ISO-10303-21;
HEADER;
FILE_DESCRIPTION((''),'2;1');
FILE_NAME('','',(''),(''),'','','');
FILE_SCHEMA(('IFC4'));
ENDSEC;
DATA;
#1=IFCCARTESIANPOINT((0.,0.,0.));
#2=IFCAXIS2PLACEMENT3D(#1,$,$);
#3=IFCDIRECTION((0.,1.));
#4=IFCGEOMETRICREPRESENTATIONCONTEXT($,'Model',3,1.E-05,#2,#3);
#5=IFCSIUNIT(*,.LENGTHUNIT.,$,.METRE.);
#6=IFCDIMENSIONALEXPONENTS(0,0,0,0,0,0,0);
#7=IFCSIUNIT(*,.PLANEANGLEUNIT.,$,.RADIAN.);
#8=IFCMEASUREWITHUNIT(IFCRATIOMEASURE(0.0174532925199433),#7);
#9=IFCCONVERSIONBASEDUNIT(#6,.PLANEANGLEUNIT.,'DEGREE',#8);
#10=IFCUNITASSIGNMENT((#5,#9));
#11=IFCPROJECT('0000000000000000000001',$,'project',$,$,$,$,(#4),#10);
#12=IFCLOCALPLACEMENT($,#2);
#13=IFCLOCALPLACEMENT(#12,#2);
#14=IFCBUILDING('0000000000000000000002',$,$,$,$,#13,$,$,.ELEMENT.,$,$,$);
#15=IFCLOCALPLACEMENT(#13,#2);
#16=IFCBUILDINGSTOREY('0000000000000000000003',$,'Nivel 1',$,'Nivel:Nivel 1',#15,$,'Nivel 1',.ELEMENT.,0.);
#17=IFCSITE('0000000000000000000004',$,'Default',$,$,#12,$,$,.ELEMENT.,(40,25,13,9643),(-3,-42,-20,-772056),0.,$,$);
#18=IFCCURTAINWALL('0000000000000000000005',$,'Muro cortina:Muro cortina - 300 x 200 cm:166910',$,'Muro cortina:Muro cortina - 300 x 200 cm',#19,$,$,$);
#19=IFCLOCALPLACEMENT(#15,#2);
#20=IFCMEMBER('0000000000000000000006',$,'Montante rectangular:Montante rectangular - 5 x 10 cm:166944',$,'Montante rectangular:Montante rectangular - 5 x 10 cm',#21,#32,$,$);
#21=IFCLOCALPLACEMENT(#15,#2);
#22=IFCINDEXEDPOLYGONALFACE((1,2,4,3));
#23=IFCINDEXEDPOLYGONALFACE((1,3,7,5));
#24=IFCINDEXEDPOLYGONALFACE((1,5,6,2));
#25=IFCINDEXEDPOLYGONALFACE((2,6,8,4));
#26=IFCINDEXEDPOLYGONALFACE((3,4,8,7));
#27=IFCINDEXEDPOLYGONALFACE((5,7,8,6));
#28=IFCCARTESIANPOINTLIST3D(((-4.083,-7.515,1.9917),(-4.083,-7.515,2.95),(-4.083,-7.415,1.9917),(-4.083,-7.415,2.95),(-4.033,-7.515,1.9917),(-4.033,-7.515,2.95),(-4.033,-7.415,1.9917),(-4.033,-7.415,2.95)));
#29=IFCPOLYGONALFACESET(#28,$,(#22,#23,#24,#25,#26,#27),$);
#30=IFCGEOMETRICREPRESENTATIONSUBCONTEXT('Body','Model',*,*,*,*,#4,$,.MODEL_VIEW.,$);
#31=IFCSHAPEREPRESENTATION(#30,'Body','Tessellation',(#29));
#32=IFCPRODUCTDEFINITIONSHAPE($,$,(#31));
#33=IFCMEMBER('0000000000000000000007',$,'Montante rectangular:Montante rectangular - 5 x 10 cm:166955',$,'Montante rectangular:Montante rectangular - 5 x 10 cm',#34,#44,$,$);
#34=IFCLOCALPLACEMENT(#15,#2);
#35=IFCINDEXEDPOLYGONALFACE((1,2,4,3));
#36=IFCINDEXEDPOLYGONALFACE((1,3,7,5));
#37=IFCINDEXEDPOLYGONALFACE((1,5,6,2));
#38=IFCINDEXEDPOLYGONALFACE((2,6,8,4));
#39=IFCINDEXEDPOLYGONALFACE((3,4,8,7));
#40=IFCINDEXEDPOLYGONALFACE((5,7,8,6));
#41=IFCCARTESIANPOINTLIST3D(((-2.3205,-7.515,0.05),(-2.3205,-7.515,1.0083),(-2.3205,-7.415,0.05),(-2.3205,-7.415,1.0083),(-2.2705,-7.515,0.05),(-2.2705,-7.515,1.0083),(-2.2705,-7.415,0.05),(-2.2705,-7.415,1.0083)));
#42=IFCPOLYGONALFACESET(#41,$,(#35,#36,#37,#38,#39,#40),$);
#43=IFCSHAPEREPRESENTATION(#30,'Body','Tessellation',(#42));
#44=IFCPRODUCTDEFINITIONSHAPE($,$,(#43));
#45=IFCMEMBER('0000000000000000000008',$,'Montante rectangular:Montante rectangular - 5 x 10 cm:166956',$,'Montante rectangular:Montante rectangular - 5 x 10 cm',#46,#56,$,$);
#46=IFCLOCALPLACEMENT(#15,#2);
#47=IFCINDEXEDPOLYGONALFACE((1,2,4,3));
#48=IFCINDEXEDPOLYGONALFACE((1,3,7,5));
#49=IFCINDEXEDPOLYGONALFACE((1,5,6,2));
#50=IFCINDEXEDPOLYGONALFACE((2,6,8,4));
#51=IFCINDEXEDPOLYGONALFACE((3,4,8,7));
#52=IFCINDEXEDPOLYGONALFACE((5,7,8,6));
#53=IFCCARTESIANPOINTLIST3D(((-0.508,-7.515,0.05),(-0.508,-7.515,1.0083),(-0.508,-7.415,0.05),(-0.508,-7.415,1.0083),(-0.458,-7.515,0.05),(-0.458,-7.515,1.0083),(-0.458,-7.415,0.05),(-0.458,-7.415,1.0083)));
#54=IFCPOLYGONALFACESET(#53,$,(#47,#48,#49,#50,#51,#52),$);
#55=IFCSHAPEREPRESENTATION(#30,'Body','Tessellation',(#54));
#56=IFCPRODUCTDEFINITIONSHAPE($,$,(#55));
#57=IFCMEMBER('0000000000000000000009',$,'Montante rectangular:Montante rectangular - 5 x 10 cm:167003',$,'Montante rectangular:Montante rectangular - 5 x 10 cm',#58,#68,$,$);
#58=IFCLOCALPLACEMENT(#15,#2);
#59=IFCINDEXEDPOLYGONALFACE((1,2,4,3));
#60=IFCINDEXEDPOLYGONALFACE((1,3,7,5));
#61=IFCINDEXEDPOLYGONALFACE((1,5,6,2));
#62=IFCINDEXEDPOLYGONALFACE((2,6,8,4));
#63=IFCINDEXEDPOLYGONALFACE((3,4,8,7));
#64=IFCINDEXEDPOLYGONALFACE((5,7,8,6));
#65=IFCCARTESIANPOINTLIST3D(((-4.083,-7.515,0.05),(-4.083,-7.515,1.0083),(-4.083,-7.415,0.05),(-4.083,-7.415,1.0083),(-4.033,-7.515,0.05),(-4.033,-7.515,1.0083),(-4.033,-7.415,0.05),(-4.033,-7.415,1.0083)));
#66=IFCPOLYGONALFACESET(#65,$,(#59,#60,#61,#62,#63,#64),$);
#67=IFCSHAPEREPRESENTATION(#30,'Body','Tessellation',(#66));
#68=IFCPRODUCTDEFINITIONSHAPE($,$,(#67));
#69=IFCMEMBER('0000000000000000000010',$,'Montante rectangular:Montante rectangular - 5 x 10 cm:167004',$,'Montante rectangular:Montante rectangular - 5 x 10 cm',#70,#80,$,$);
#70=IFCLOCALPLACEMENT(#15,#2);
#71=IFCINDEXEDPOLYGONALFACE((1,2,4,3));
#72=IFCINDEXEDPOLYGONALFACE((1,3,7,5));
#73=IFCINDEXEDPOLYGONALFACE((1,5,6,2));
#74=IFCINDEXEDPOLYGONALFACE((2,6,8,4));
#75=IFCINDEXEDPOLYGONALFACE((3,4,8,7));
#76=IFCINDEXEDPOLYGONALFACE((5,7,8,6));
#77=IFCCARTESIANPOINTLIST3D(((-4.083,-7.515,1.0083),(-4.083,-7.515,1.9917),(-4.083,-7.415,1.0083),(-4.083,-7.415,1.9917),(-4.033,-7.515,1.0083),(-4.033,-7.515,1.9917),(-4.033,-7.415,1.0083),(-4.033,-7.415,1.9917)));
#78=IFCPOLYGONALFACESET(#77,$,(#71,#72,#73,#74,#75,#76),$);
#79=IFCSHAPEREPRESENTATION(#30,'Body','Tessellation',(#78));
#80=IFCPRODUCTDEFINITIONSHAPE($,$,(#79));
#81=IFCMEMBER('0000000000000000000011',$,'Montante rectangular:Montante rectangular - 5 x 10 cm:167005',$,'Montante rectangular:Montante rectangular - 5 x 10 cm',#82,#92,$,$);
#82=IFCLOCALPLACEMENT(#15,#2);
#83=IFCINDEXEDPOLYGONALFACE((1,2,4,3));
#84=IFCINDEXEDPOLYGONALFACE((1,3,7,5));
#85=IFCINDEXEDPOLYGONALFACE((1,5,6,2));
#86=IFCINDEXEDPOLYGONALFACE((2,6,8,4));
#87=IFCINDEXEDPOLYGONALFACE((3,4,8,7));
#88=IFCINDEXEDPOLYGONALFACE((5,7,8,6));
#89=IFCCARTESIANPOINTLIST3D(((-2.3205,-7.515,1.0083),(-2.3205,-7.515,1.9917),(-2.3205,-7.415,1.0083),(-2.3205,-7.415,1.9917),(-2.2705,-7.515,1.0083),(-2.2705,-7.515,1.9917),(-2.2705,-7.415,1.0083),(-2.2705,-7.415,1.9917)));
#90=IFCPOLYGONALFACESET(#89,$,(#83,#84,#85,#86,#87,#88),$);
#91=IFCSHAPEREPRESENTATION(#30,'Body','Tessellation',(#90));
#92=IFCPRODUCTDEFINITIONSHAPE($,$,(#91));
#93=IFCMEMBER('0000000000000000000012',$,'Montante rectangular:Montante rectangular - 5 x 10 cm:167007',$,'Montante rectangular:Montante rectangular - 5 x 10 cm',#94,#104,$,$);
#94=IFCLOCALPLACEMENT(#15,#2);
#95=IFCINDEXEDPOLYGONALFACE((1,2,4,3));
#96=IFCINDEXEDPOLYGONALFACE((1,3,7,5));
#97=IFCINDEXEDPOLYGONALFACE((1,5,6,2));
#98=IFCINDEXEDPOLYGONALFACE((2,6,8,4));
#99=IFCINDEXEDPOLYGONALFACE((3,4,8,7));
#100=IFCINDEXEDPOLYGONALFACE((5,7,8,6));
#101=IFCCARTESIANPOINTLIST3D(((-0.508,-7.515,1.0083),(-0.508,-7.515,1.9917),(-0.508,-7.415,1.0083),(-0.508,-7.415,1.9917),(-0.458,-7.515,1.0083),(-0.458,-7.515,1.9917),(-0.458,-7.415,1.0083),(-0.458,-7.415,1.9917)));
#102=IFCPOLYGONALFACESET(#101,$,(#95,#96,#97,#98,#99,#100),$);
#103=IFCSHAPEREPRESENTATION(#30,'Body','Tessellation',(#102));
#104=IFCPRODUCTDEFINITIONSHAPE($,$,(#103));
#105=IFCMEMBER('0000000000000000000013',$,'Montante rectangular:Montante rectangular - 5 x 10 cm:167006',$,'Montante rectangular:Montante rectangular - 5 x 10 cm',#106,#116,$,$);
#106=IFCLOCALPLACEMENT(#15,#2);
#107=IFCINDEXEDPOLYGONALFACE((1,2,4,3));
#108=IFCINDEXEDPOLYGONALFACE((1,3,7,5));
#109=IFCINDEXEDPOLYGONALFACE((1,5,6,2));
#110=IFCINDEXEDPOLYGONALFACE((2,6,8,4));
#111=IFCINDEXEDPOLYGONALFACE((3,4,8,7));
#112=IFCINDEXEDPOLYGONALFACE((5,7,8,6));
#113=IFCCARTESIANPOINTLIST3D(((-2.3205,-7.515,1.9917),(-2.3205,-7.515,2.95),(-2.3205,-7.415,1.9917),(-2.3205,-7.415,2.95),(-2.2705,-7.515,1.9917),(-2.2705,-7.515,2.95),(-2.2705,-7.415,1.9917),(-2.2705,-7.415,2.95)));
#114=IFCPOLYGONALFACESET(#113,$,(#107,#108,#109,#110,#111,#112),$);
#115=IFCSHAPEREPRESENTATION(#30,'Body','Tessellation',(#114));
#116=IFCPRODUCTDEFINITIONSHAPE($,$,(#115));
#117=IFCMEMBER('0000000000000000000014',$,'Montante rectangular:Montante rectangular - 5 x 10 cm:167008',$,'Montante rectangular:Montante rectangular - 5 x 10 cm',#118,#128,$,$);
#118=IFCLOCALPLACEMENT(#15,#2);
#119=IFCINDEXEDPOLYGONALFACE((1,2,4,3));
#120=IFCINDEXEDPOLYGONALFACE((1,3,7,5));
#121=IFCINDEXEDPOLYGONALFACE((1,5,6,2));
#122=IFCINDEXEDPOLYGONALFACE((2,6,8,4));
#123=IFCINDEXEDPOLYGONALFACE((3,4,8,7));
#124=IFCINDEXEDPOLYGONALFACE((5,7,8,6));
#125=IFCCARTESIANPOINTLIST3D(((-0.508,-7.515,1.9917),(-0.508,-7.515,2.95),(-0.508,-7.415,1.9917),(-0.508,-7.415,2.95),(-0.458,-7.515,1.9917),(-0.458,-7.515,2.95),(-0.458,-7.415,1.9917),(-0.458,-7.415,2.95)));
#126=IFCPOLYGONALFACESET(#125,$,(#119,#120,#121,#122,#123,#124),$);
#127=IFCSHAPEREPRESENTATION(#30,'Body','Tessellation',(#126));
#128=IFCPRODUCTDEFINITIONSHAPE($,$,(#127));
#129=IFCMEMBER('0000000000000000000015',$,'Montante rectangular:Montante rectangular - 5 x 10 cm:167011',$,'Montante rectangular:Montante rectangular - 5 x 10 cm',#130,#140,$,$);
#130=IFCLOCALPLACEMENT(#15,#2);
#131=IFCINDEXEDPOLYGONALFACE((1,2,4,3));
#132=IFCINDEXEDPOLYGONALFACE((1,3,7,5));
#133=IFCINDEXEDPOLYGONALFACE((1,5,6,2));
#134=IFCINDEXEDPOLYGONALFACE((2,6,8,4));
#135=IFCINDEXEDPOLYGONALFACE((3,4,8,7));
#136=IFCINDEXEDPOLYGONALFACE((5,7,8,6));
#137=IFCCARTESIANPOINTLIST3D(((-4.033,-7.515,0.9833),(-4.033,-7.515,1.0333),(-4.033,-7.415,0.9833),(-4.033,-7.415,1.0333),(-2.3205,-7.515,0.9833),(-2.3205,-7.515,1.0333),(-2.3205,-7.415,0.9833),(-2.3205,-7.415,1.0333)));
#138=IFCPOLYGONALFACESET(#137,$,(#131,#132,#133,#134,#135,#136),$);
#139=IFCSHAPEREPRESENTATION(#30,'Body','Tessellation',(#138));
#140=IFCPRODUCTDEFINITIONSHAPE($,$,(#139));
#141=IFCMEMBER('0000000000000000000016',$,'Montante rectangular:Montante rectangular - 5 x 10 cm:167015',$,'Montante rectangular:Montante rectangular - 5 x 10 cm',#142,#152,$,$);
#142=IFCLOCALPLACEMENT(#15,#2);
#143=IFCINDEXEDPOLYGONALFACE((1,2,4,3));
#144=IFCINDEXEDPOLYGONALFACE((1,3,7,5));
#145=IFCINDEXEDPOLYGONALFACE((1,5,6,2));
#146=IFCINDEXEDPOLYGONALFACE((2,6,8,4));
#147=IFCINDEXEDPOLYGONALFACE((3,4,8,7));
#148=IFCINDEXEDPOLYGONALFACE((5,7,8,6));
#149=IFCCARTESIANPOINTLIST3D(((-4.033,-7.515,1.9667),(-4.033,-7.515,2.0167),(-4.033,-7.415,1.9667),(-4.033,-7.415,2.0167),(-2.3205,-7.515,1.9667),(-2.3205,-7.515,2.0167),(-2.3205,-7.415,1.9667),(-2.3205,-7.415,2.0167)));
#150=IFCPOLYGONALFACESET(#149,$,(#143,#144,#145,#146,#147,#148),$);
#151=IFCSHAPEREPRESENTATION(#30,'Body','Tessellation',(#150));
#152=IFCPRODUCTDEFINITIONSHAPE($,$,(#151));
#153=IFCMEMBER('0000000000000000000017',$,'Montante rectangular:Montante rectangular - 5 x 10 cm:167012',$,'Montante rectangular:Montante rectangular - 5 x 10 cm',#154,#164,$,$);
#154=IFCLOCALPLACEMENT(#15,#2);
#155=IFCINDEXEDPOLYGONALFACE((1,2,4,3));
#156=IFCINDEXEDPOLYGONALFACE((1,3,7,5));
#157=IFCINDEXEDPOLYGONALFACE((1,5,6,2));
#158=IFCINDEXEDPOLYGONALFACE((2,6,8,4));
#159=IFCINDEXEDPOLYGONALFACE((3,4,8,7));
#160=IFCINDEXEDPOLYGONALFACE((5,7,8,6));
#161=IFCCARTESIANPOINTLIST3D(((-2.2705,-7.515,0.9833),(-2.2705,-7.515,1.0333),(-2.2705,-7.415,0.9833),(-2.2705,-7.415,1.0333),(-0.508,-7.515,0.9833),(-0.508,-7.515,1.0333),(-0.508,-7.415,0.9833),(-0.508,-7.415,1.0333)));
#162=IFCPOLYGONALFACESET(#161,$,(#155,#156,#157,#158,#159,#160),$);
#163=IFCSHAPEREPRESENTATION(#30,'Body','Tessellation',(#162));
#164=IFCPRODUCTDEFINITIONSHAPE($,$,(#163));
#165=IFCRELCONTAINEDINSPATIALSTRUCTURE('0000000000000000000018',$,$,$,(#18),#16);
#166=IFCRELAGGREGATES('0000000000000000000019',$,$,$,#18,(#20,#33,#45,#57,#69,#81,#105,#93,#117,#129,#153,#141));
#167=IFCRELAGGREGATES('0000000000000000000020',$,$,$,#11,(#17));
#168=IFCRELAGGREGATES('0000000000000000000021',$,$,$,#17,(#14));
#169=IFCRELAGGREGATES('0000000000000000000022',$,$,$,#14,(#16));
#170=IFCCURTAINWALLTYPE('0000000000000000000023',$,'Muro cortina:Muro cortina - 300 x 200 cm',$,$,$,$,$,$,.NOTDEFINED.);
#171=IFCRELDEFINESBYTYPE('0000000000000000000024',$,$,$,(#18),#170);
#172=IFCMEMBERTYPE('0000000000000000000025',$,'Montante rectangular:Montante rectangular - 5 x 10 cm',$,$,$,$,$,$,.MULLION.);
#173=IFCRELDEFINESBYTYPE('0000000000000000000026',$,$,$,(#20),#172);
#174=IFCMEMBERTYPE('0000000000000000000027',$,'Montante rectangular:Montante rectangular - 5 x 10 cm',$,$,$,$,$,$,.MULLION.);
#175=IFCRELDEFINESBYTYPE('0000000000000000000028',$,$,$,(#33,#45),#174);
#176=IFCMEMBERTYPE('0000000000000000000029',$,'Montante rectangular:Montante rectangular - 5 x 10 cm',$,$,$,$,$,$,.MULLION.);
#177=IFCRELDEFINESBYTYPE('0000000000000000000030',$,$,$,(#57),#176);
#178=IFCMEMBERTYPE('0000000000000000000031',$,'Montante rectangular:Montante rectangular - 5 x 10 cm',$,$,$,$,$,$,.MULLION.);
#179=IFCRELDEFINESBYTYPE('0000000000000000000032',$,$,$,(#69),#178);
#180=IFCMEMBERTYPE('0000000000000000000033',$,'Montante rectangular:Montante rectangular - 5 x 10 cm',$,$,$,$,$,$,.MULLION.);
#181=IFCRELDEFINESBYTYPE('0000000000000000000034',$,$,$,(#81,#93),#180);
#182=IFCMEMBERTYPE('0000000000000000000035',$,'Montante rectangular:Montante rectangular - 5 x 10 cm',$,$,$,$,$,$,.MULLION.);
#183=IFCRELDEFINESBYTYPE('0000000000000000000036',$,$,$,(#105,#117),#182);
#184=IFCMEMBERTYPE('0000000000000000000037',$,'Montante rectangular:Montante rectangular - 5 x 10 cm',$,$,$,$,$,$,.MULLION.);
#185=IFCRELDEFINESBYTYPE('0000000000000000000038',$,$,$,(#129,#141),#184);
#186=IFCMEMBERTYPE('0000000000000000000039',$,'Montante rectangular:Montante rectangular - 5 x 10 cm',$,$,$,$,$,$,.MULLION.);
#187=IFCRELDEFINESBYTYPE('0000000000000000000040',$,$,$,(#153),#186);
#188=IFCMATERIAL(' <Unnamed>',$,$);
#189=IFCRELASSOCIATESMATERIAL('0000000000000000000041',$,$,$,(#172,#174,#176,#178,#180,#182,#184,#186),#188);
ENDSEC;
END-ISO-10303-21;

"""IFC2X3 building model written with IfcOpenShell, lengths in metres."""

from ifc_helpers import new_model, entity, si_unit, converted_unit, direction, frame, origin, origin_2d_with_axis, place, context, subcontext, project, spatial, rectangle, extrude, source, transform, mapped, material, type_object, type_shapes, element, aggregate, save


model = new_model("IFC2X3")

# Units and contexts
model_context = context("Model", 3, precision=1e-05, world=origin(), true_north=direction((0.0, 1.0)))
body_context = subcontext(model_context, "Body", "Model", "MODEL_VIEW")
ifc_project = project(units=[si_unit("LENGTHUNIT", "METRE"), converted_unit("PLANEANGLEUNIT", "DEGREE", entity("IfcRatioMeasure", 0.0174532925199433), si_unit("PLANEANGLEUNIT", "RADIAN"), dimensions=[0, 0, 0, 0, 0, 0, 0])], contexts=[model_context])

# Site, building, storey
site_placement = place(None, origin())
site = spatial("IfcSite", under=ifc_project, at=site_placement, Name="Default", CompositionType="ELEMENT", RefLatitude=(40, 25, 13, 9643), RefLongitude=(-3, -42, -20, -772056), RefElevation=0.0)
building_placement = place(site_placement, origin())
building = spatial("IfcBuilding", under=site, at=building_placement, CompositionType="ELEMENT")
storey_placement = place(building_placement, origin())
storey = spatial("IfcBuildingStorey", under=building, at=storey_placement, Name="Nivel 1", ObjectType="Nivel:Nivel 1", LongName="Nivel 1", CompositionType="ELEMENT", Elevation=0.0)

# Curtain wall, members
curtain_wall_type = type_object("IfcCurtainWallType", Name="Muro cortina:Muro cortina - 300 x 200 cm", PredefinedType="NOTDEFINED")
curtain_wall_placement = place(storey_placement, origin())
curtain_wall = element("IfcCurtainWall", 1, at=curtain_wall_placement, inside=storey, type_object=curtain_wall_type, Name="Muro cortina:Muro cortina - 300 x 200 cm:166910", ObjectType="Muro cortina:Muro cortina - 300 x 200 cm")
ifc_material_1 = material(Name=" <Unnamed>")
member_type_1 = type_object("IfcMemberType", Name="Montante rectangular:Montante rectangular - 5 x 10 cm", PredefinedType="MULLION", material=ifc_material_1)
shared_shape_1 = source(origin(), body_context, "Body", "SweptSolid", [
    extrude(rectangle(XDim=0.1, YDim=0.05, at=origin_2d_with_axis()), frame((-0.025, 0.0, -0.9583), z_axis=(0.0, 0.0, 1.0), x_axis=(0.0, -1.0, 0.0)), (0.0, 0.0, 1.0), 0.9583),
])
type_shapes(member_type_1, [shared_shape_1])
member_1_placement = place(storey_placement, frame((-4.083, -7.465, 2.95), z_axis=(0.0, 0.0, 1.0), x_axis=(-1.0, 0.0, 0.0)))
member_1 = element("IfcMember", 2, at=member_1_placement, type_object=member_type_1, Name="Montante rectangular:Montante rectangular - 5 x 10 cm:166944", ObjectType="Montante rectangular:Montante rectangular - 5 x 10 cm", context=body_context, shape_type="MappedRepresentation", body=[
    mapped(shared_shape_1, transform((0.0, 0.0, 0.0), scale=1.0)),
])
member_type_2 = type_object("IfcMemberType", Name="Montante rectangular:Montante rectangular - 5 x 10 cm", PredefinedType="MULLION", material=ifc_material_1)
shared_shape_2 = source(origin(), body_context, "Body", "SweptSolid", [
    extrude(rectangle(XDim=0.1, YDim=0.05, at=origin_2d_with_axis()), frame((0.0, 0.0, -0.9583), z_axis=(0.0, 0.0, 1.0), x_axis=(0.0, -1.0, 0.0)), (0.0, 0.0, 1.0), 0.9583),
])
type_shapes(member_type_2, [shared_shape_2])
member_2_placement = place(storey_placement, frame((-2.2955, -7.465, 0.05), z_axis=(0.0, 0.0, -1.0), x_axis=(1.0, 0.0, 0.0)))
member_2 = element("IfcMember", 3, at=member_2_placement, type_object=member_type_2, Name="Montante rectangular:Montante rectangular - 5 x 10 cm:166955", ObjectType="Montante rectangular:Montante rectangular - 5 x 10 cm", context=body_context, shape_type="MappedRepresentation", body=[
    mapped(shared_shape_2, transform((0.0, 0.0, 0.0), scale=1.0)),
])
member_3_placement = place(storey_placement, frame((-0.483, -7.465, 0.05), z_axis=(0.0, 0.0, -1.0), x_axis=(1.0, 0.0, 0.0)))
member_3 = element("IfcMember", 4, at=member_3_placement, type_object=member_type_2, Name="Montante rectangular:Montante rectangular - 5 x 10 cm:166956", ObjectType="Montante rectangular:Montante rectangular - 5 x 10 cm", context=body_context, shape_type="MappedRepresentation", body=[
    mapped(shared_shape_2, transform((0.0, 0.0, 0.0), scale=1.0)),
])
member_type_3 = type_object("IfcMemberType", Name="Montante rectangular:Montante rectangular - 5 x 10 cm", PredefinedType="MULLION", material=ifc_material_1)
shared_shape_3 = source(origin(), body_context, "Body", "SweptSolid", [
    extrude(rectangle(XDim=0.1, YDim=0.05, at=origin_2d_with_axis()), frame((-0.025, 0.0, -0.9583), z_axis=(0.0, 0.0, 1.0), x_axis=(0.0, -1.0, 0.0)), (0.0, 0.0, 1.0), 0.9583),
])
type_shapes(member_type_3, [shared_shape_3])
member_4_placement = place(storey_placement, frame((-4.083, -7.465, 1.0083), z_axis=(0.0, 0.0, 1.0), x_axis=(-1.0, 0.0, 0.0)))
member_4 = element("IfcMember", 5, at=member_4_placement, type_object=member_type_3, Name="Montante rectangular:Montante rectangular - 5 x 10 cm:167003", ObjectType="Montante rectangular:Montante rectangular - 5 x 10 cm", context=body_context, shape_type="MappedRepresentation", body=[
    mapped(shared_shape_3, transform((0.0, 0.0, 0.0), scale=1.0)),
])
member_type_4 = type_object("IfcMemberType", Name="Montante rectangular:Montante rectangular - 5 x 10 cm", PredefinedType="MULLION", material=ifc_material_1)
shared_shape_4 = source(origin(), body_context, "Body", "SweptSolid", [
    extrude(rectangle(XDim=0.1, YDim=0.05, at=origin_2d_with_axis()), frame((-0.025, 0.0, -0.9833), z_axis=(0.0, 0.0, 1.0), x_axis=(0.0, -1.0, 0.0)), (0.0, 0.0, 1.0), 0.9833),
])
type_shapes(member_type_4, [shared_shape_4])
member_5_placement = place(storey_placement, frame((-4.083, -7.465, 1.9917), z_axis=(0.0, 0.0, 1.0), x_axis=(-1.0, 0.0, 0.0)))
member_5 = element("IfcMember", 6, at=member_5_placement, type_object=member_type_4, Name="Montante rectangular:Montante rectangular - 5 x 10 cm:167004", ObjectType="Montante rectangular:Montante rectangular - 5 x 10 cm", context=body_context, shape_type="MappedRepresentation", body=[
    mapped(shared_shape_4, transform((0.0, 0.0, 0.0), scale=1.0)),
])
member_type_5 = type_object("IfcMemberType", Name="Montante rectangular:Montante rectangular - 5 x 10 cm", PredefinedType="MULLION", material=ifc_material_1)
shared_shape_5 = source(origin(), body_context, "Body", "SweptSolid", [
    extrude(rectangle(XDim=0.1, YDim=0.05, at=origin_2d_with_axis()), frame((0.0, 0.0, -0.9833), z_axis=(0.0, 0.0, 1.0), x_axis=(0.0, -1.0, 0.0)), (0.0, 0.0, 1.0), 0.9833),
])
type_shapes(member_type_5, [shared_shape_5])
member_6_placement = place(storey_placement, frame((-2.2955, -7.465, 1.0083), z_axis=(0.0, 0.0, -1.0), x_axis=(1.0, 0.0, 0.0)))
member_6 = element("IfcMember", 7, at=member_6_placement, type_object=member_type_5, Name="Montante rectangular:Montante rectangular - 5 x 10 cm:167005", ObjectType="Montante rectangular:Montante rectangular - 5 x 10 cm", context=body_context, shape_type="MappedRepresentation", body=[
    mapped(shared_shape_5, transform((0.0, 0.0, 0.0), scale=1.0)),
])
member_7_placement = place(storey_placement, frame((-0.483, -7.465, 1.0083), z_axis=(0.0, 0.0, -1.0), x_axis=(1.0, 0.0, 0.0)))
member_7 = element("IfcMember", 8, at=member_7_placement, type_object=member_type_5, Name="Montante rectangular:Montante rectangular - 5 x 10 cm:167007", ObjectType="Montante rectangular:Montante rectangular - 5 x 10 cm", context=body_context, shape_type="MappedRepresentation", body=[
    mapped(shared_shape_5, transform((0.0, 0.0, 0.0), scale=1.0)),
])
member_type_6 = type_object("IfcMemberType", Name="Montante rectangular:Montante rectangular - 5 x 10 cm", PredefinedType="MULLION", material=ifc_material_1)
shared_shape_6 = source(origin(), body_context, "Body", "SweptSolid", [
    extrude(rectangle(XDim=0.1, YDim=0.05, at=origin_2d_with_axis()), frame((0.0, 0.0, -0.9583), z_axis=(0.0, 0.0, 1.0), x_axis=(0.0, -1.0, 0.0)), (0.0, 0.0, 1.0), 0.9583),
])
type_shapes(member_type_6, [shared_shape_6])
member_8_placement = place(storey_placement, frame((-2.2955, -7.465, 1.9917), z_axis=(0.0, 0.0, -1.0), x_axis=(1.0, 0.0, 0.0)))
member_8 = element("IfcMember", 9, at=member_8_placement, type_object=member_type_6, Name="Montante rectangular:Montante rectangular - 5 x 10 cm:167006", ObjectType="Montante rectangular:Montante rectangular - 5 x 10 cm", context=body_context, shape_type="MappedRepresentation", body=[
    mapped(shared_shape_6, transform((0.0, 0.0, 0.0), scale=1.0)),
])
member_9_placement = place(storey_placement, frame((-0.483, -7.465, 1.9917), z_axis=(0.0, 0.0, -1.0), x_axis=(1.0, 0.0, 0.0)))
member_9 = element("IfcMember", 10, at=member_9_placement, type_object=member_type_6, Name="Montante rectangular:Montante rectangular - 5 x 10 cm:167008", ObjectType="Montante rectangular:Montante rectangular - 5 x 10 cm", context=body_context, shape_type="MappedRepresentation", body=[
    mapped(shared_shape_6, transform((0.0, 0.0, 0.0), scale=1.0)),
])
member_type_7 = type_object("IfcMemberType", Name="Montante rectangular:Montante rectangular - 5 x 10 cm", PredefinedType="MULLION", material=ifc_material_1)
shared_shape_7 = source(origin(), body_context, "Body", "SweptSolid", [
    extrude(rectangle(XDim=0.1, YDim=0.05, at=origin_2d_with_axis()), frame((0.0, 0.0, -1.7125), z_axis=(0.0, 0.0, 1.0), x_axis=(0.0, -1.0, 0.0)), (0.0, 0.0, 1.0), 1.7125),
])
type_shapes(member_type_7, [shared_shape_7])
member_10_placement = place(storey_placement, frame((-2.3205, -7.465, 1.0083), z_axis=(1.0, 0.0, 0.0), x_axis=(0.0, 0.0, 1.0)))
member_10 = element("IfcMember", 11, at=member_10_placement, type_object=member_type_7, Name="Montante rectangular:Montante rectangular - 5 x 10 cm:167011", ObjectType="Montante rectangular:Montante rectangular - 5 x 10 cm", context=body_context, shape_type="MappedRepresentation", body=[
    mapped(shared_shape_7, transform((0.0, 0.0, 0.0), scale=1.0)),
])
member_11_placement = place(storey_placement, frame((-2.3205, -7.465, 1.9917), z_axis=(1.0, 0.0, 0.0), x_axis=(0.0, 0.0, 1.0)))
member_11 = element("IfcMember", 12, at=member_11_placement, type_object=member_type_7, Name="Montante rectangular:Montante rectangular - 5 x 10 cm:167015", ObjectType="Montante rectangular:Montante rectangular - 5 x 10 cm", context=body_context, shape_type="MappedRepresentation", body=[
    mapped(shared_shape_7, transform((0.0, 0.0, 0.0), scale=1.0)),
])
member_type_8 = type_object("IfcMemberType", Name="Montante rectangular:Montante rectangular - 5 x 10 cm", PredefinedType="MULLION", material=ifc_material_1)
shared_shape_8 = source(origin(), body_context, "Body", "SweptSolid", [
    extrude(rectangle(XDim=0.1, YDim=0.05, at=origin_2d_with_axis()), frame((0.0, 0.0, -1.7625), z_axis=(0.0, 0.0, 1.0), x_axis=(0.0, -1.0, 0.0)), (0.0, 0.0, 1.0), 1.7625),
])
type_shapes(member_type_8, [shared_shape_8])
member_12_placement = place(storey_placement, frame((-0.508, -7.465, 1.0083), z_axis=(1.0, 0.0, 0.0), x_axis=(0.0, 0.0, 1.0)))
member_12 = element("IfcMember", 13, at=member_12_placement, type_object=member_type_8, Name="Montante rectangular:Montante rectangular - 5 x 10 cm:167012", ObjectType="Montante rectangular:Montante rectangular - 5 x 10 cm", context=body_context, shape_type="MappedRepresentation", body=[
    mapped(shared_shape_8, transform((0.0, 0.0, 0.0), scale=1.0)),
])

aggregate(curtain_wall, [member_1, member_2, member_3, member_4, member_5, member_6, member_8, member_7, member_9, member_10, member_12, member_11])

save(model, "model.ifc")
